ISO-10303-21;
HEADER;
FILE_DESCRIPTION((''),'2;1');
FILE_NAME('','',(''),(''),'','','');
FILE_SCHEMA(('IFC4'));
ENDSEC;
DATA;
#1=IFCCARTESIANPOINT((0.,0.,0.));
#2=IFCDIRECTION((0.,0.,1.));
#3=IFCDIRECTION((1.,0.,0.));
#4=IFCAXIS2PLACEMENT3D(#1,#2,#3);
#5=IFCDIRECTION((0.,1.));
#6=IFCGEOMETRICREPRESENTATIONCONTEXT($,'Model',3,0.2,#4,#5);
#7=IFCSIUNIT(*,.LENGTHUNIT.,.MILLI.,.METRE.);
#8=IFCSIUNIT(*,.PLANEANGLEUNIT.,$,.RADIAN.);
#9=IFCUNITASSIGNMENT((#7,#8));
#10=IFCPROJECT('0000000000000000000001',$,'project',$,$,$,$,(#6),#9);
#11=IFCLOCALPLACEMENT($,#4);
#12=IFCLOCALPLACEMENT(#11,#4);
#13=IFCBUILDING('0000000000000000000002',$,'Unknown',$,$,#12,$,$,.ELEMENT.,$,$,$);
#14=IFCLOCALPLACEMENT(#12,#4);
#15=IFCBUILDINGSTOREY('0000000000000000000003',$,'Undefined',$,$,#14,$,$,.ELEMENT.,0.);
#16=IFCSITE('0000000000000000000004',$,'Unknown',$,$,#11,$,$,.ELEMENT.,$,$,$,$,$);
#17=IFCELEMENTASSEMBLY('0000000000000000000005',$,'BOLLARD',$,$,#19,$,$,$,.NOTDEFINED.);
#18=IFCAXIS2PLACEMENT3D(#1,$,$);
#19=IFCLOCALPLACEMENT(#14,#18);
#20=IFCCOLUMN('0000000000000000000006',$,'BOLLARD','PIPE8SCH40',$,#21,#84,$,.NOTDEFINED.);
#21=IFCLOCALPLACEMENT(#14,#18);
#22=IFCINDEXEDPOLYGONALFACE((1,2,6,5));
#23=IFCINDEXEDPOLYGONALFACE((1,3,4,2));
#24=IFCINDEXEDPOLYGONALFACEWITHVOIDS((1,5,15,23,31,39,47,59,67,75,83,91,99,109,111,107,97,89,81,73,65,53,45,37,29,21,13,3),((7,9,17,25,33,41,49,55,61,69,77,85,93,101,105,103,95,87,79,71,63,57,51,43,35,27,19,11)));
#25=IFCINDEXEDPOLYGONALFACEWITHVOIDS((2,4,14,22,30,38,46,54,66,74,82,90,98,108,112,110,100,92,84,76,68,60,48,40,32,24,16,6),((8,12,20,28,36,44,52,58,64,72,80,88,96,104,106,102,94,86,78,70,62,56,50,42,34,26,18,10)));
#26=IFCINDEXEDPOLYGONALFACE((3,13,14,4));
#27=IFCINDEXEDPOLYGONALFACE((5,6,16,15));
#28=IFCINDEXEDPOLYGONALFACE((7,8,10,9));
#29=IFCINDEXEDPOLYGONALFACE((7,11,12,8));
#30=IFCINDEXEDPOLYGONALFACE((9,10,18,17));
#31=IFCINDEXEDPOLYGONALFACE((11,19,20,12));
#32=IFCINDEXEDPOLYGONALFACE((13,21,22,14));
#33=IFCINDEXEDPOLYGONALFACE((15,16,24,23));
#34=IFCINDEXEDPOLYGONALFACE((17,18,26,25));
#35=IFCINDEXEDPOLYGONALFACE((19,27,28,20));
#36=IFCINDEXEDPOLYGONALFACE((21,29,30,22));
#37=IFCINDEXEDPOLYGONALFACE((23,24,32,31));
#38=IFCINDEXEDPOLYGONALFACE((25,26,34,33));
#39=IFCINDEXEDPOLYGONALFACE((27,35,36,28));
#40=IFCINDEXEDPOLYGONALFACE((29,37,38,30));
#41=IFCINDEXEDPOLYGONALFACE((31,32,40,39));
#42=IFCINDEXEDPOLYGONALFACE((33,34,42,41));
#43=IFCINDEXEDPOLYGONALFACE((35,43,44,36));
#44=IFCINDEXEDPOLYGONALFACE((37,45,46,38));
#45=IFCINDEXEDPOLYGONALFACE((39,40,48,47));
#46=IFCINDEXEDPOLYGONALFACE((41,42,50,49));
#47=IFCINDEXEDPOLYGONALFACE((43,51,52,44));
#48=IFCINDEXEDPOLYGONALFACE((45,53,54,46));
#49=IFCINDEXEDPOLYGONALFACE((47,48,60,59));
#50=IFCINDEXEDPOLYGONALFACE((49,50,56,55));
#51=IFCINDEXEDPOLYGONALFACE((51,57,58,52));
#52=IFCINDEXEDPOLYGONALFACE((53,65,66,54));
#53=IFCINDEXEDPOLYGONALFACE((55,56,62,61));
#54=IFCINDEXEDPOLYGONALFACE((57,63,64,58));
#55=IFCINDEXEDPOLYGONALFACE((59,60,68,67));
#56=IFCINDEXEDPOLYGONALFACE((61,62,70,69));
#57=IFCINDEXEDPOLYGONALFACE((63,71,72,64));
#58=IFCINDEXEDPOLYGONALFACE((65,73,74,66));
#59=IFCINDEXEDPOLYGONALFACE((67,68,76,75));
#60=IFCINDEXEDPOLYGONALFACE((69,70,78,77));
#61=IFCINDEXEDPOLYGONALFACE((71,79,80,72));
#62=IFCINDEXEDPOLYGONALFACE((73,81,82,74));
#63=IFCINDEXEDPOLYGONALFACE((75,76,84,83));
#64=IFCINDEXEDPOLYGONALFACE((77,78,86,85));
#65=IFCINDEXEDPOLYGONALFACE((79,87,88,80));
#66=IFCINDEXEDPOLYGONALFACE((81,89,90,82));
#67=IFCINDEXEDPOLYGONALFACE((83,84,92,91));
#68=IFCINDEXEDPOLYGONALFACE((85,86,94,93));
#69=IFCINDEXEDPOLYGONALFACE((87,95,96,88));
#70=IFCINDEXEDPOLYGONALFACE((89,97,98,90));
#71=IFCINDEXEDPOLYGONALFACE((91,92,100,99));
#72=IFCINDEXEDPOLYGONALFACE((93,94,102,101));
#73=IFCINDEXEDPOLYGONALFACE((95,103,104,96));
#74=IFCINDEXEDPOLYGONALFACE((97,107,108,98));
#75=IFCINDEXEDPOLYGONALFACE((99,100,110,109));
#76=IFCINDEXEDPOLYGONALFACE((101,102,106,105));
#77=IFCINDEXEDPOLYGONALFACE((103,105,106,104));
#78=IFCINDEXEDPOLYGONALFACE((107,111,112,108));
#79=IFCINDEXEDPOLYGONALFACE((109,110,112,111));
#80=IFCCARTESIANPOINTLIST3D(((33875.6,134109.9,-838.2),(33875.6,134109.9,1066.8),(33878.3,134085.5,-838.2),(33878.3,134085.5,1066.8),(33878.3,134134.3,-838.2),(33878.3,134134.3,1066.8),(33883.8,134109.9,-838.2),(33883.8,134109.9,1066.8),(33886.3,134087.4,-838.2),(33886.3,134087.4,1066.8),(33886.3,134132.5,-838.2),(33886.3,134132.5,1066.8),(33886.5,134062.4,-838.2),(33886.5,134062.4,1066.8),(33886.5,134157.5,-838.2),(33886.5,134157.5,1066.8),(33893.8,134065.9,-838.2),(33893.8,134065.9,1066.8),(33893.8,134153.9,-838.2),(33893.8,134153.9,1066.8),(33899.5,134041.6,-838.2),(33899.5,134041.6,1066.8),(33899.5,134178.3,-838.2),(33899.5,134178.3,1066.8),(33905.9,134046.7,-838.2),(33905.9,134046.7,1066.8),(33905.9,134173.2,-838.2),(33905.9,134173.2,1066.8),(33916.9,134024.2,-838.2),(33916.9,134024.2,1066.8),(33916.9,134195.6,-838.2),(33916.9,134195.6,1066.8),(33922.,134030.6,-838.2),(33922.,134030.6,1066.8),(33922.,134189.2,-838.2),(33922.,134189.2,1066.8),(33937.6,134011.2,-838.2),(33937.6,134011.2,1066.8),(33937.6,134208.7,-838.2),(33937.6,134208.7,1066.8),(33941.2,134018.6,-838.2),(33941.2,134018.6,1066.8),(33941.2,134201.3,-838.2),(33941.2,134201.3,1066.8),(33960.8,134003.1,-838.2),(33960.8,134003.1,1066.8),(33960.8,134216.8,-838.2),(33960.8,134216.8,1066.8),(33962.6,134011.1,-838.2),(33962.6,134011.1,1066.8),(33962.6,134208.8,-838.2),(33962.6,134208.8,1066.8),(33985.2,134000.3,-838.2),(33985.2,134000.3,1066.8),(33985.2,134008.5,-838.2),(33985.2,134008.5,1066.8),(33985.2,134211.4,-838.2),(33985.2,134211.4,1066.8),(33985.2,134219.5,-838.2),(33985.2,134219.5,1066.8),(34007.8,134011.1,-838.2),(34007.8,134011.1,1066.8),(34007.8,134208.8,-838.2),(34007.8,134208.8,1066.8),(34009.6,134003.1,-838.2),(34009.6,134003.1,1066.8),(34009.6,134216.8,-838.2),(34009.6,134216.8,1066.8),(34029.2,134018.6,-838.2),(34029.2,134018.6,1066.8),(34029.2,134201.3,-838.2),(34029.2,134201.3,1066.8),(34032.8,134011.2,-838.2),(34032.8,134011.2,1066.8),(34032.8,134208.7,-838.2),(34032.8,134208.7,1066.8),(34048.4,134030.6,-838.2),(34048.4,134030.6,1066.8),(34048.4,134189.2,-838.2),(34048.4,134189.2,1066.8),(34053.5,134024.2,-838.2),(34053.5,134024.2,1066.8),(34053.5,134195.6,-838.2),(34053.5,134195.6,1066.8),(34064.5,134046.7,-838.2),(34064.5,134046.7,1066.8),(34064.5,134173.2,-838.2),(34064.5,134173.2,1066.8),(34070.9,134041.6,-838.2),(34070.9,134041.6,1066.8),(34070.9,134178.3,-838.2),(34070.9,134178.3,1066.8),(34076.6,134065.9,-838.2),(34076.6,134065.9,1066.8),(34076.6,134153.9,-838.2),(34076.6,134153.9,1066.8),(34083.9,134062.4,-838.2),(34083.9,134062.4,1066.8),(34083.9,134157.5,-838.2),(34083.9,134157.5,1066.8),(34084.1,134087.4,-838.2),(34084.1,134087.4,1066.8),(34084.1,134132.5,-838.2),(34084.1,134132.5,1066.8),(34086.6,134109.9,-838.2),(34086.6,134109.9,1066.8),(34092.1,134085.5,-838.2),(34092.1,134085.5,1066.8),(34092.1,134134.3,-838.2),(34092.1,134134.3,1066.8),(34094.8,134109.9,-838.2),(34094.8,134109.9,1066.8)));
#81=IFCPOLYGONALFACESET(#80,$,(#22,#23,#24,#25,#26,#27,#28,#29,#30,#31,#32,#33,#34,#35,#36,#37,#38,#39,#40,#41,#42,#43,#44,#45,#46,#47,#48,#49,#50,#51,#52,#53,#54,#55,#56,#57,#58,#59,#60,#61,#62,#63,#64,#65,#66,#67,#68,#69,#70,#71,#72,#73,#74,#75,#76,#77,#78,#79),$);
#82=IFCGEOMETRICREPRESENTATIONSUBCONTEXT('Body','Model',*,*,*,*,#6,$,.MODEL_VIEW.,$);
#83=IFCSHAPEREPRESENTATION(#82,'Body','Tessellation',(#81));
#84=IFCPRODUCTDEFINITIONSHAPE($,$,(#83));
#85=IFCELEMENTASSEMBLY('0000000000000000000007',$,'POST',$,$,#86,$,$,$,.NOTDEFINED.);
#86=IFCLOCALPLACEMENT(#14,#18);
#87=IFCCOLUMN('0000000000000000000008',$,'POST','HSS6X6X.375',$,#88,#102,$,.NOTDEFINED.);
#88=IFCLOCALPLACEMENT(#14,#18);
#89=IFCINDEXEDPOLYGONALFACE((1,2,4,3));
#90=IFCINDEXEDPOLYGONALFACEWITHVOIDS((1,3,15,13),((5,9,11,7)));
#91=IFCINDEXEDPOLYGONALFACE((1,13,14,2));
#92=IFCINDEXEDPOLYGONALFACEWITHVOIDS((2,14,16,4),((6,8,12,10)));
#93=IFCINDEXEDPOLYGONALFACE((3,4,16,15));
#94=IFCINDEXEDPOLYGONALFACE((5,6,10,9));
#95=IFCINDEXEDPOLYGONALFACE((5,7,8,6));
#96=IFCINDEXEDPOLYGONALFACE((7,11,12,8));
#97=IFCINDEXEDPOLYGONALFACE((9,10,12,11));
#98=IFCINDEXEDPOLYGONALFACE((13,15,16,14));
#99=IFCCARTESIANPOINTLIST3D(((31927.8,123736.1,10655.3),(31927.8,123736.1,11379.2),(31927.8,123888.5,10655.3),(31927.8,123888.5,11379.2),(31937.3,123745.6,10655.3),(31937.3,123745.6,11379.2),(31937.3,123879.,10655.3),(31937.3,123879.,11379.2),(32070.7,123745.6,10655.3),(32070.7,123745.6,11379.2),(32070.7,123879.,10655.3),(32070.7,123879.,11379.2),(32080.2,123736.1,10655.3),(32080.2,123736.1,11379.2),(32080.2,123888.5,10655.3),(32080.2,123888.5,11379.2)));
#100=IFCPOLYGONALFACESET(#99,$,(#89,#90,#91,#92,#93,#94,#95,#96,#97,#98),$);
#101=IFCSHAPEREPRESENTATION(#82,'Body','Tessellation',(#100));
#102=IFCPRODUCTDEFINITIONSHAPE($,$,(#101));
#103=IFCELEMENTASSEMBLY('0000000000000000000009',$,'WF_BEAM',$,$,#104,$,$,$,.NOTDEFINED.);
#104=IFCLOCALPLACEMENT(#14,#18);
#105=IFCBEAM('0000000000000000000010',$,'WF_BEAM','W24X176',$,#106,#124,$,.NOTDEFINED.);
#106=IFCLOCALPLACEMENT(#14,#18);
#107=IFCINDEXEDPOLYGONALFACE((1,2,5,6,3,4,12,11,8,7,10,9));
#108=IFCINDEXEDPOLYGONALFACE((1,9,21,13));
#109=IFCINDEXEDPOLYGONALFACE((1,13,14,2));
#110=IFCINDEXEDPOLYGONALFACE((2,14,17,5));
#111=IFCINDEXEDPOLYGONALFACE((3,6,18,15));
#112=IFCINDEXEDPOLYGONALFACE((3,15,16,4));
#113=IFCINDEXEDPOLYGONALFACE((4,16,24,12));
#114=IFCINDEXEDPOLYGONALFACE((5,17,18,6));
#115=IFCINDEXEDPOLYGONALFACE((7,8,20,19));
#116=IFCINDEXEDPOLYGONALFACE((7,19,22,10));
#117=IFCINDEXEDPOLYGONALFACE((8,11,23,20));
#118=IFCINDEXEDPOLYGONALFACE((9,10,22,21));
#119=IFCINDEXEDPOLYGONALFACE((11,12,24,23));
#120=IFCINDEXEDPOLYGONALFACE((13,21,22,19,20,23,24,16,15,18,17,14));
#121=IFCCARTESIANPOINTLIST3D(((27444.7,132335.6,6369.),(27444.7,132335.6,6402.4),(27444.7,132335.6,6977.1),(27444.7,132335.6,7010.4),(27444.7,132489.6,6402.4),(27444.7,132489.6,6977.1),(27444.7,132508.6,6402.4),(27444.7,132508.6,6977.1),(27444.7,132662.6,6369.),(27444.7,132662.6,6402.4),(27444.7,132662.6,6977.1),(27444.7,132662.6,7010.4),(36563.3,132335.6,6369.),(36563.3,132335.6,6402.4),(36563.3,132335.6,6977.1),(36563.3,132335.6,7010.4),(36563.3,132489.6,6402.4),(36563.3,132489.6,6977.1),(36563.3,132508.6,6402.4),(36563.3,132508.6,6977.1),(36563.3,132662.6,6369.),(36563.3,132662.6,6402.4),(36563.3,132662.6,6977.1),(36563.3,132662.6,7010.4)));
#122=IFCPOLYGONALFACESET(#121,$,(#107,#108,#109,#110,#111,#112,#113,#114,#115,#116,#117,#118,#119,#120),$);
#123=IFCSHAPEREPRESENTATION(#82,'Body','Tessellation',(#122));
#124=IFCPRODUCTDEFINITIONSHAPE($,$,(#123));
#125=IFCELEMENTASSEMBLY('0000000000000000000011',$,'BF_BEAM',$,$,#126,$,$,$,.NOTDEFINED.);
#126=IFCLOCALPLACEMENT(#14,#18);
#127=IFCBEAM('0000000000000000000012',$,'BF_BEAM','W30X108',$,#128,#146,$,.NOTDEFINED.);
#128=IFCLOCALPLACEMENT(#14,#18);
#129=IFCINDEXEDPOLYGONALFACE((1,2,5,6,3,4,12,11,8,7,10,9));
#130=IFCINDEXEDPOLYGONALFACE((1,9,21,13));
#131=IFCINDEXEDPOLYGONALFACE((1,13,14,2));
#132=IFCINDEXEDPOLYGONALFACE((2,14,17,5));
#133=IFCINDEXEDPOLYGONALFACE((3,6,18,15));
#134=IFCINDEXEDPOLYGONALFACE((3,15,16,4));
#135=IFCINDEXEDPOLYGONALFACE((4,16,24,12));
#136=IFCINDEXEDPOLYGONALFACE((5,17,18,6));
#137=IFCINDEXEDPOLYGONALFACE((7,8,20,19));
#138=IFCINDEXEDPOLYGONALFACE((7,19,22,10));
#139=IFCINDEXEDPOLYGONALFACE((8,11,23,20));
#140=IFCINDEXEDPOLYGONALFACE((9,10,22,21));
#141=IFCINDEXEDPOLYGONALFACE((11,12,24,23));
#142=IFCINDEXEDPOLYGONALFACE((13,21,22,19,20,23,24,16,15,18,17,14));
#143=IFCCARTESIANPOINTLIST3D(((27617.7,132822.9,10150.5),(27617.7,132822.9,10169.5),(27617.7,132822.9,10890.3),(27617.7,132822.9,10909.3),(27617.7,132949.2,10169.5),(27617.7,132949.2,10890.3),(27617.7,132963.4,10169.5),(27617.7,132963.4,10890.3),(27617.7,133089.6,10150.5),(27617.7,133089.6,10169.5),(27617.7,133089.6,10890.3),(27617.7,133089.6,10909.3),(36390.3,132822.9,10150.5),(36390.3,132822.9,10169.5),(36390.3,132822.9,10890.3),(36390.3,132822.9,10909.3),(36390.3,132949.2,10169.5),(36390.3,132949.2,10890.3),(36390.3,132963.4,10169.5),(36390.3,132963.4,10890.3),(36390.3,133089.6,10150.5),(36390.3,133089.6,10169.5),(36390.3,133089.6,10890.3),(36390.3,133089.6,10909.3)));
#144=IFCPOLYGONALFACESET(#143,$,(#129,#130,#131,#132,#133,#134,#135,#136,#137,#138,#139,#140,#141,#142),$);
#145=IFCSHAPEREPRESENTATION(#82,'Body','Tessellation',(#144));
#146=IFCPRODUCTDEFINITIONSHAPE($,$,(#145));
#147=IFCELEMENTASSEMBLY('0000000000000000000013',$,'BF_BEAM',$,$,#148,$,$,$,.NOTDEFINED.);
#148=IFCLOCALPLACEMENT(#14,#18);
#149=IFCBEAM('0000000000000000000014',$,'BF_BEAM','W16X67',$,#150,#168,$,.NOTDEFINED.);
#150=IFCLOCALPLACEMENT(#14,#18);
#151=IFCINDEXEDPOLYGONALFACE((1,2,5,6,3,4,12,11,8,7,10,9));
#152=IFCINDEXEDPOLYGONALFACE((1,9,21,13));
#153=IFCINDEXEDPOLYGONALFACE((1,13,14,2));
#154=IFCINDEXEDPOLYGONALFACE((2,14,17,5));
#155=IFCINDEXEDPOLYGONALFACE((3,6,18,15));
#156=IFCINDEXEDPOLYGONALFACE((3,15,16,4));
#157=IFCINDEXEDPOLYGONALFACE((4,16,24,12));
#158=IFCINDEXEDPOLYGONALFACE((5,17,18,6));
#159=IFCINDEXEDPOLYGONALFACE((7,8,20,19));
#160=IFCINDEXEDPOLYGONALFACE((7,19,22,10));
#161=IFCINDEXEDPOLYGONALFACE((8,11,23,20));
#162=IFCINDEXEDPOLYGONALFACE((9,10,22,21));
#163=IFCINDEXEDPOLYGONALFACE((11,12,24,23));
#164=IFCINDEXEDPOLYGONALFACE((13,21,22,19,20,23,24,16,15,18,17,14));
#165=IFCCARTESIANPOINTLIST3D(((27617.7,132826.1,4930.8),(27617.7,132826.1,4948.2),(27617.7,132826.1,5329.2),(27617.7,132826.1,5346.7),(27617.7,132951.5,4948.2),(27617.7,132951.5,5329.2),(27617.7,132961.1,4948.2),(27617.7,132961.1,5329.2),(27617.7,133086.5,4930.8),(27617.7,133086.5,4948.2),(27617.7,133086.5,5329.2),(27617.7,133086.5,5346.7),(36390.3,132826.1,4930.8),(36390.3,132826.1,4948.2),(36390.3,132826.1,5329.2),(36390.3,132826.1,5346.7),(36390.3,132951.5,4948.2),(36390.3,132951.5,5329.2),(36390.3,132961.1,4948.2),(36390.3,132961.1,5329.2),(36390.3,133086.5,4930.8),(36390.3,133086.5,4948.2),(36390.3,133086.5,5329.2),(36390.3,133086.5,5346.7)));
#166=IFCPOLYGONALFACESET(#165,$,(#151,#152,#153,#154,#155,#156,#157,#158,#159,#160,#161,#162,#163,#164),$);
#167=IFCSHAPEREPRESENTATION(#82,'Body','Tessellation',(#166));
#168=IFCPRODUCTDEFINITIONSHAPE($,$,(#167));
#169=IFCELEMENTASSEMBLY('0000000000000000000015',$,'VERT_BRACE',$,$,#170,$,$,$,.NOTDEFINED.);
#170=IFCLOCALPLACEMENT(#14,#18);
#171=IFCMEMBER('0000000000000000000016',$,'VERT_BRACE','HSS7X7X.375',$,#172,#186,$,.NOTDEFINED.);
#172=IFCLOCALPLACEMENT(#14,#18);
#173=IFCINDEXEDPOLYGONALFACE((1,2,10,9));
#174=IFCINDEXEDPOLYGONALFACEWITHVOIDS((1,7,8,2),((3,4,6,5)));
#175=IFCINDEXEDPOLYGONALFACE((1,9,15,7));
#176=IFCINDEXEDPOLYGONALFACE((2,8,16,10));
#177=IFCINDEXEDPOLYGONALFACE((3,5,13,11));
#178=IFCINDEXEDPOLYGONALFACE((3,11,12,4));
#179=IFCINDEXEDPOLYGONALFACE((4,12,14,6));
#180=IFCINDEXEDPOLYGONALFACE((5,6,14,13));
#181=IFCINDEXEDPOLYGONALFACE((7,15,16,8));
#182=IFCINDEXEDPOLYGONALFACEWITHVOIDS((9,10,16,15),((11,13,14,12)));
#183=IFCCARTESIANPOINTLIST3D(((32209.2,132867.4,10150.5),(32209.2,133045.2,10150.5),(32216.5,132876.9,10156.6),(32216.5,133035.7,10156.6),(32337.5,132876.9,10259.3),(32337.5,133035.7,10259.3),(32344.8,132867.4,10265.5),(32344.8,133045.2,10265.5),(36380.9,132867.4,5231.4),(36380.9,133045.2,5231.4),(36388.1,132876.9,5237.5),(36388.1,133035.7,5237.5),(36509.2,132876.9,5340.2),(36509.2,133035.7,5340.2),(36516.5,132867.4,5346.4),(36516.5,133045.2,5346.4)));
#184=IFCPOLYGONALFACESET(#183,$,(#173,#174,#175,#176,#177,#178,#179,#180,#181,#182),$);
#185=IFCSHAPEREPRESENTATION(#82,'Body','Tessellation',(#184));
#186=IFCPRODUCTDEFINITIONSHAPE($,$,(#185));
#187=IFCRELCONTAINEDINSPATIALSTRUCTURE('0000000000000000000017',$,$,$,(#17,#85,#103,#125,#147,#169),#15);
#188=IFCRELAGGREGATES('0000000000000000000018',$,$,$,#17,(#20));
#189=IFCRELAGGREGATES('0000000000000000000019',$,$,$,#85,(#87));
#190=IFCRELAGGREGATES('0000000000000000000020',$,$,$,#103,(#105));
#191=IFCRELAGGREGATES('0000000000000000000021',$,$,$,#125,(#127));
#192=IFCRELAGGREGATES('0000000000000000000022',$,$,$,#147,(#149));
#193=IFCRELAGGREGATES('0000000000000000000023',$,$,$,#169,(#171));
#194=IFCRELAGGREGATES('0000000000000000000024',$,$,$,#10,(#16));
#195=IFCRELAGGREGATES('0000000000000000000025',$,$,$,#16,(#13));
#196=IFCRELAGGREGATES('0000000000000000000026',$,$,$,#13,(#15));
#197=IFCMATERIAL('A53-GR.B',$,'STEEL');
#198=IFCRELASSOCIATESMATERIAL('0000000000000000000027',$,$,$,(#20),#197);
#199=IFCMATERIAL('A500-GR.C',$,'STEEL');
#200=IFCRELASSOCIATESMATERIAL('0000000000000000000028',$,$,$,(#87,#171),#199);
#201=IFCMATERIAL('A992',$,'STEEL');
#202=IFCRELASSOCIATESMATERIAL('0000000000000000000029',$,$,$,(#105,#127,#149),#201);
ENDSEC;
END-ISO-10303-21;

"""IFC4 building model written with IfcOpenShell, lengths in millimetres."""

from ifc_helpers import new_model, si_unit, direction, frame, origin_with_axes, place, context, subcontext, project, spatial, line, indexed_curve, outline, extrude, material, element, aggregate, save


model = new_model("IFC4")

# Units and contexts
model_context = context("Model", 3, precision=0.2, world=origin_with_axes(), true_north=direction((0.0, 1.0)))
body_context = subcontext(model_context, "Body", "Model", "MODEL_VIEW")
ifc_project = project(units=[si_unit("LENGTHUNIT", "METRE", prefix="MILLI"), si_unit("PLANEANGLEUNIT", "RADIAN")], contexts=[model_context])

# Site, building, storey
site_placement = place(None, origin_with_axes())
site = spatial("IfcSite", under=ifc_project, at=site_placement, Name="Unknown", CompositionType="ELEMENT")
building_placement = place(site_placement, origin_with_axes())
building = spatial("IfcBuilding", under=site, at=building_placement, Name="Unknown", CompositionType="ELEMENT")
storey_placement = place(building_placement, origin_with_axes())
storey = spatial("IfcBuildingStorey", under=building, at=storey_placement, Name="Undefined", CompositionType="ELEMENT", Elevation=0.0)

# Element assemblies, columns
ifc_material_1 = material(Name="A992", Category="STEEL")
ifc_material_2 = material(Name="A53-GR.B", Category="STEEL")
assembly_1_placement = place(storey_placement, frame((33985.2, 134109.9, -838.2), z_axis=(-1.0, 0.0, 0.0), x_axis=(0.0, 0.0, 1.0)))
assembly_1 = element("IfcElementAssembly", 1, at=assembly_1_placement, inside=storey, Name="BOLLARD", PredefinedType="NOTDEFINED")
column_1_placement = place(assembly_1_placement, origin_with_axes())
column_1 = element("IfcColumn", 2, at=column_1_placement, material=ifc_material_2, Name="BOLLARD", Description="PIPE8SCH40", PredefinedType="NOTDEFINED", context=body_context, shape_type="SolidModel", body=[
    extrude(outline(indexed_curve([(109.6, 0.0), (106.9, 24.4), (98.7, 47.6), (85.7, 68.3), (68.3, 85.7), (47.6, 98.7), (24.4, 106.9), (0.0, 109.6), (-24.4, 106.9), (-47.6, 98.7), (-68.3, 85.7), (-85.7, 68.3), (-98.7, 47.6), (-106.9, 24.4), (-109.6, 0.0), (-106.9, -24.4), (-98.7, -47.6), (-85.7, -68.3), (-68.3, -85.7), (-47.6, -98.7), (-24.4, -106.9), (0.0, -109.6), (24.4, -106.9), (47.6, -98.7), (68.3, -85.7), (85.7, -68.3), (98.7, -47.6), (106.9, -24.4)], segments=[line(1, 2, 3, 4, 5, 6, 7, 8, 9, 10, 11, 12, 13, 14, 15, 16, 17, 18, 19, 20, 21, 22, 23, 24, 25, 26, 27, 28, 1)]), holes=[indexed_curve([(101.4, 0.0), (98.9, -22.6), (91.4, -44.0), (79.3, -63.2), (63.2, -79.3), (44.0, -91.4), (22.6, -98.9), (0.0, -101.4), (-22.6, -98.9), (-44.0, -91.4), (-63.2, -79.3), (-79.3, -63.2), (-91.4, -44.0), (-98.9, -22.6), (-101.4, 0.0), (-98.9, 22.6), (-91.4, 44.0), (-79.3, 63.2), (-63.2, 79.3), (-44.0, 91.4), (-22.6, 98.9), (0.0, 101.4), (22.6, 98.9), (44.0, 91.4), (63.2, 79.3), (79.3, 63.2), (91.4, 44.0), (98.9, 22.6)], segments=[line(1, 2, 3, 4, 5, 6, 7, 8, 9, 10, 11, 12, 13, 14, 15, 16, 17, 18, 19, 20, 21, 22, 23, 24, 25, 26, 27, 28, 1)])]), frame((0.0, 0.0, 0.0), z_axis=(-1.0, 0.0, 0.0), x_axis=(0.0, 0.0, 1.0)), (0.0, 0.0, -1.0), 1905.0),
])
aggregate(assembly_1, [column_1])
assembly_2_placement = place(storey_placement, frame((32004.0, 123812.3, 10655.3), z_axis=(0.0, -1.0, 0.0), x_axis=(0.0, 0.0, 1.0)))
assembly_2 = element("IfcElementAssembly", 3, at=assembly_2_placement, inside=storey, Name="POST", PredefinedType="NOTDEFINED")
ifc_material_3 = material(Name="A500-GR.C", Category="STEEL")
column_2_placement = place(assembly_2_placement, origin_with_axes())
column_2 = element("IfcColumn", 4, at=column_2_placement, material=ifc_material_3, Name="POST", Description="HSS6X6X.375", PredefinedType="NOTDEFINED", context=body_context, shape_type="SolidModel", body=[
    extrude(outline(indexed_curve([(-76.2, -76.2), (76.2, -76.2), (76.2, 76.2), (-76.2, 76.2)], segments=[line(1, 2, 3, 4, 1)]), holes=[indexed_curve([(-66.7, -66.7), (-66.7, 66.7), (66.7, 66.7), (66.7, -66.7)], segments=[line(1, 2, 3, 4, 1)])]), frame((0.0, 0.0, 0.0), z_axis=(-1.0, 0.0, 0.0), x_axis=(0.0, 0.0, 1.0)), (0.0, 0.0, -1.0), 723.9),
])
aggregate(assembly_2, [column_2])

# Element assemblies, beams
assembly_3_placement = place(storey_placement, frame((27444.7, 132499.1, 6689.7), z_axis=(0.0, -1.0, 0.0), x_axis=(1.0, 0.0, 0.0)))
assembly_3 = element("IfcElementAssembly", 5, at=assembly_3_placement, inside=storey, Name="WF_BEAM", PredefinedType="NOTDEFINED")
beam_1_placement = place(assembly_3_placement, origin_with_axes())
beam_1 = element("IfcBeam", 6, at=beam_1_placement, material=ifc_material_1, Name="WF_BEAM", Description="W24X176", PredefinedType="NOTDEFINED", context=body_context, shape_type="SolidModel", body=[
    extrude(outline(indexed_curve([(-163.5, -320.7), (163.5, -320.7), (163.5, -287.3), (9.5, -287.3), (9.5, 287.3), (163.5, 287.3), (163.5, 320.7), (-163.5, 320.7), (-163.5, 287.3), (-9.5, 287.3), (-9.5, -287.3), (-163.5, -287.3)], segments=[line(1, 2, 3, 4, 5, 6, 7, 8, 9, 10, 11, 12, 1)])), frame((0.0, 0.0, 0.0), z_axis=(-1.0, 0.0, 0.0), x_axis=(0.0, 0.0, 1.0)), (0.0, 0.0, -1.0), 9118.6),
])
aggregate(assembly_3, [beam_1])
assembly_4_placement = place(storey_placement, frame((27617.7, 132956.3, 10529.9), z_axis=(0.0, -1.0, 0.0), x_axis=(1.0, 0.0, 0.0)))
assembly_4 = element("IfcElementAssembly", 7, at=assembly_4_placement, inside=storey, Name="BF_BEAM", PredefinedType="NOTDEFINED")
beam_2_placement = place(assembly_4_placement, origin_with_axes())
beam_2 = element("IfcBeam", 8, at=beam_2_placement, material=ifc_material_1, Name="BF_BEAM", Description="W30X108", PredefinedType="NOTDEFINED", context=body_context, shape_type="SolidModel", body=[
    extrude(outline(indexed_curve([(-133.3, -379.4), (133.3, -379.4), (133.3, -360.4), (7.1, -360.4), (7.1, 360.4), (133.3, 360.4), (133.3, 379.4), (-133.3, 379.4), (-133.3, 360.4), (-7.1, 360.4), (-7.1, -360.4), (-133.3, -360.4)], segments=[line(1, 2, 3, 4, 5, 6, 7, 8, 9, 10, 11, 12, 1)])), frame((0.0, 0.0, 0.0), z_axis=(-1.0, 0.0, 0.0), x_axis=(0.0, 0.0, 1.0)), (0.0, 0.0, -1.0), 8772.5),
])
aggregate(assembly_4, [beam_2])
assembly_5_placement = place(storey_placement, frame((27617.7, 132956.3, 5138.7), z_axis=(0.0, -1.0, 0.0), x_axis=(1.0, 0.0, 0.0)))
assembly_5 = element("IfcElementAssembly", 9, at=assembly_5_placement, inside=storey, Name="BF_BEAM", PredefinedType="NOTDEFINED")
beam_3_placement = place(assembly_5_placement, origin_with_axes())
beam_3 = element("IfcBeam", 10, at=beam_3_placement, material=ifc_material_1, Name="BF_BEAM", Description="W16X67", PredefinedType="NOTDEFINED", context=body_context, shape_type="SolidModel", body=[
    extrude(outline(indexed_curve([(-130.2, -208.0), (130.2, -208.0), (130.2, -190.5), (4.8, -190.5), (4.8, 190.5), (130.2, 190.5), (130.2, 208.0), (-130.2, 208.0), (-130.2, 190.5), (-4.8, 190.5), (-4.8, -190.5), (-130.2, -190.5)], segments=[line(1, 2, 3, 4, 5, 6, 7, 8, 9, 10, 11, 12, 1)])), frame((0.0, 0.0, 0.0), z_axis=(-1.0, 0.0, 0.0), x_axis=(0.0, 0.0, 1.0)), (0.0, 0.0, -1.0), 8772.5),
])
aggregate(assembly_5, [beam_3])

# Element assembly, member
assembly_6_placement = place(storey_placement, frame((36448.7, 132956.3, 5288.9), z_axis=(0.0, 1.0, 0.0), x_axis=(-0.646788, 0.0, 0.76267)))
assembly_6 = element("IfcElementAssembly", 11, at=assembly_6_placement, inside=storey, Name="VERT_BRACE", PredefinedType="NOTDEFINED")
member_1_placement = place(assembly_6_placement, origin_with_axes())
member_1 = element("IfcMember", 12, at=member_1_placement, material=ifc_material_3, Name="VERT_BRACE", Description="HSS7X7X.375", PredefinedType="NOTDEFINED", context=body_context, shape_type="SolidModel", body=[
    extrude(outline(indexed_curve([(-88.9, -88.9), (88.9, -88.9), (88.9, 88.9), (-88.9, 88.9)], segments=[line(1, 2, 3, 4, 1)]), holes=[indexed_curve([(-79.4, -79.4), (-79.4, 79.4), (79.4, 79.4), (79.4, -79.4)], segments=[line(1, 2, 3, 4, 1)])]), frame((0.0, 0.0, 0.0), z_axis=(-1.0, 0.0, 0.0), x_axis=(0.0, 0.0, 1.0)), (0.0, 0.0, -1.0), 6449.9),
])
aggregate(assembly_6, [member_1])

save(model, "model.ifc")
